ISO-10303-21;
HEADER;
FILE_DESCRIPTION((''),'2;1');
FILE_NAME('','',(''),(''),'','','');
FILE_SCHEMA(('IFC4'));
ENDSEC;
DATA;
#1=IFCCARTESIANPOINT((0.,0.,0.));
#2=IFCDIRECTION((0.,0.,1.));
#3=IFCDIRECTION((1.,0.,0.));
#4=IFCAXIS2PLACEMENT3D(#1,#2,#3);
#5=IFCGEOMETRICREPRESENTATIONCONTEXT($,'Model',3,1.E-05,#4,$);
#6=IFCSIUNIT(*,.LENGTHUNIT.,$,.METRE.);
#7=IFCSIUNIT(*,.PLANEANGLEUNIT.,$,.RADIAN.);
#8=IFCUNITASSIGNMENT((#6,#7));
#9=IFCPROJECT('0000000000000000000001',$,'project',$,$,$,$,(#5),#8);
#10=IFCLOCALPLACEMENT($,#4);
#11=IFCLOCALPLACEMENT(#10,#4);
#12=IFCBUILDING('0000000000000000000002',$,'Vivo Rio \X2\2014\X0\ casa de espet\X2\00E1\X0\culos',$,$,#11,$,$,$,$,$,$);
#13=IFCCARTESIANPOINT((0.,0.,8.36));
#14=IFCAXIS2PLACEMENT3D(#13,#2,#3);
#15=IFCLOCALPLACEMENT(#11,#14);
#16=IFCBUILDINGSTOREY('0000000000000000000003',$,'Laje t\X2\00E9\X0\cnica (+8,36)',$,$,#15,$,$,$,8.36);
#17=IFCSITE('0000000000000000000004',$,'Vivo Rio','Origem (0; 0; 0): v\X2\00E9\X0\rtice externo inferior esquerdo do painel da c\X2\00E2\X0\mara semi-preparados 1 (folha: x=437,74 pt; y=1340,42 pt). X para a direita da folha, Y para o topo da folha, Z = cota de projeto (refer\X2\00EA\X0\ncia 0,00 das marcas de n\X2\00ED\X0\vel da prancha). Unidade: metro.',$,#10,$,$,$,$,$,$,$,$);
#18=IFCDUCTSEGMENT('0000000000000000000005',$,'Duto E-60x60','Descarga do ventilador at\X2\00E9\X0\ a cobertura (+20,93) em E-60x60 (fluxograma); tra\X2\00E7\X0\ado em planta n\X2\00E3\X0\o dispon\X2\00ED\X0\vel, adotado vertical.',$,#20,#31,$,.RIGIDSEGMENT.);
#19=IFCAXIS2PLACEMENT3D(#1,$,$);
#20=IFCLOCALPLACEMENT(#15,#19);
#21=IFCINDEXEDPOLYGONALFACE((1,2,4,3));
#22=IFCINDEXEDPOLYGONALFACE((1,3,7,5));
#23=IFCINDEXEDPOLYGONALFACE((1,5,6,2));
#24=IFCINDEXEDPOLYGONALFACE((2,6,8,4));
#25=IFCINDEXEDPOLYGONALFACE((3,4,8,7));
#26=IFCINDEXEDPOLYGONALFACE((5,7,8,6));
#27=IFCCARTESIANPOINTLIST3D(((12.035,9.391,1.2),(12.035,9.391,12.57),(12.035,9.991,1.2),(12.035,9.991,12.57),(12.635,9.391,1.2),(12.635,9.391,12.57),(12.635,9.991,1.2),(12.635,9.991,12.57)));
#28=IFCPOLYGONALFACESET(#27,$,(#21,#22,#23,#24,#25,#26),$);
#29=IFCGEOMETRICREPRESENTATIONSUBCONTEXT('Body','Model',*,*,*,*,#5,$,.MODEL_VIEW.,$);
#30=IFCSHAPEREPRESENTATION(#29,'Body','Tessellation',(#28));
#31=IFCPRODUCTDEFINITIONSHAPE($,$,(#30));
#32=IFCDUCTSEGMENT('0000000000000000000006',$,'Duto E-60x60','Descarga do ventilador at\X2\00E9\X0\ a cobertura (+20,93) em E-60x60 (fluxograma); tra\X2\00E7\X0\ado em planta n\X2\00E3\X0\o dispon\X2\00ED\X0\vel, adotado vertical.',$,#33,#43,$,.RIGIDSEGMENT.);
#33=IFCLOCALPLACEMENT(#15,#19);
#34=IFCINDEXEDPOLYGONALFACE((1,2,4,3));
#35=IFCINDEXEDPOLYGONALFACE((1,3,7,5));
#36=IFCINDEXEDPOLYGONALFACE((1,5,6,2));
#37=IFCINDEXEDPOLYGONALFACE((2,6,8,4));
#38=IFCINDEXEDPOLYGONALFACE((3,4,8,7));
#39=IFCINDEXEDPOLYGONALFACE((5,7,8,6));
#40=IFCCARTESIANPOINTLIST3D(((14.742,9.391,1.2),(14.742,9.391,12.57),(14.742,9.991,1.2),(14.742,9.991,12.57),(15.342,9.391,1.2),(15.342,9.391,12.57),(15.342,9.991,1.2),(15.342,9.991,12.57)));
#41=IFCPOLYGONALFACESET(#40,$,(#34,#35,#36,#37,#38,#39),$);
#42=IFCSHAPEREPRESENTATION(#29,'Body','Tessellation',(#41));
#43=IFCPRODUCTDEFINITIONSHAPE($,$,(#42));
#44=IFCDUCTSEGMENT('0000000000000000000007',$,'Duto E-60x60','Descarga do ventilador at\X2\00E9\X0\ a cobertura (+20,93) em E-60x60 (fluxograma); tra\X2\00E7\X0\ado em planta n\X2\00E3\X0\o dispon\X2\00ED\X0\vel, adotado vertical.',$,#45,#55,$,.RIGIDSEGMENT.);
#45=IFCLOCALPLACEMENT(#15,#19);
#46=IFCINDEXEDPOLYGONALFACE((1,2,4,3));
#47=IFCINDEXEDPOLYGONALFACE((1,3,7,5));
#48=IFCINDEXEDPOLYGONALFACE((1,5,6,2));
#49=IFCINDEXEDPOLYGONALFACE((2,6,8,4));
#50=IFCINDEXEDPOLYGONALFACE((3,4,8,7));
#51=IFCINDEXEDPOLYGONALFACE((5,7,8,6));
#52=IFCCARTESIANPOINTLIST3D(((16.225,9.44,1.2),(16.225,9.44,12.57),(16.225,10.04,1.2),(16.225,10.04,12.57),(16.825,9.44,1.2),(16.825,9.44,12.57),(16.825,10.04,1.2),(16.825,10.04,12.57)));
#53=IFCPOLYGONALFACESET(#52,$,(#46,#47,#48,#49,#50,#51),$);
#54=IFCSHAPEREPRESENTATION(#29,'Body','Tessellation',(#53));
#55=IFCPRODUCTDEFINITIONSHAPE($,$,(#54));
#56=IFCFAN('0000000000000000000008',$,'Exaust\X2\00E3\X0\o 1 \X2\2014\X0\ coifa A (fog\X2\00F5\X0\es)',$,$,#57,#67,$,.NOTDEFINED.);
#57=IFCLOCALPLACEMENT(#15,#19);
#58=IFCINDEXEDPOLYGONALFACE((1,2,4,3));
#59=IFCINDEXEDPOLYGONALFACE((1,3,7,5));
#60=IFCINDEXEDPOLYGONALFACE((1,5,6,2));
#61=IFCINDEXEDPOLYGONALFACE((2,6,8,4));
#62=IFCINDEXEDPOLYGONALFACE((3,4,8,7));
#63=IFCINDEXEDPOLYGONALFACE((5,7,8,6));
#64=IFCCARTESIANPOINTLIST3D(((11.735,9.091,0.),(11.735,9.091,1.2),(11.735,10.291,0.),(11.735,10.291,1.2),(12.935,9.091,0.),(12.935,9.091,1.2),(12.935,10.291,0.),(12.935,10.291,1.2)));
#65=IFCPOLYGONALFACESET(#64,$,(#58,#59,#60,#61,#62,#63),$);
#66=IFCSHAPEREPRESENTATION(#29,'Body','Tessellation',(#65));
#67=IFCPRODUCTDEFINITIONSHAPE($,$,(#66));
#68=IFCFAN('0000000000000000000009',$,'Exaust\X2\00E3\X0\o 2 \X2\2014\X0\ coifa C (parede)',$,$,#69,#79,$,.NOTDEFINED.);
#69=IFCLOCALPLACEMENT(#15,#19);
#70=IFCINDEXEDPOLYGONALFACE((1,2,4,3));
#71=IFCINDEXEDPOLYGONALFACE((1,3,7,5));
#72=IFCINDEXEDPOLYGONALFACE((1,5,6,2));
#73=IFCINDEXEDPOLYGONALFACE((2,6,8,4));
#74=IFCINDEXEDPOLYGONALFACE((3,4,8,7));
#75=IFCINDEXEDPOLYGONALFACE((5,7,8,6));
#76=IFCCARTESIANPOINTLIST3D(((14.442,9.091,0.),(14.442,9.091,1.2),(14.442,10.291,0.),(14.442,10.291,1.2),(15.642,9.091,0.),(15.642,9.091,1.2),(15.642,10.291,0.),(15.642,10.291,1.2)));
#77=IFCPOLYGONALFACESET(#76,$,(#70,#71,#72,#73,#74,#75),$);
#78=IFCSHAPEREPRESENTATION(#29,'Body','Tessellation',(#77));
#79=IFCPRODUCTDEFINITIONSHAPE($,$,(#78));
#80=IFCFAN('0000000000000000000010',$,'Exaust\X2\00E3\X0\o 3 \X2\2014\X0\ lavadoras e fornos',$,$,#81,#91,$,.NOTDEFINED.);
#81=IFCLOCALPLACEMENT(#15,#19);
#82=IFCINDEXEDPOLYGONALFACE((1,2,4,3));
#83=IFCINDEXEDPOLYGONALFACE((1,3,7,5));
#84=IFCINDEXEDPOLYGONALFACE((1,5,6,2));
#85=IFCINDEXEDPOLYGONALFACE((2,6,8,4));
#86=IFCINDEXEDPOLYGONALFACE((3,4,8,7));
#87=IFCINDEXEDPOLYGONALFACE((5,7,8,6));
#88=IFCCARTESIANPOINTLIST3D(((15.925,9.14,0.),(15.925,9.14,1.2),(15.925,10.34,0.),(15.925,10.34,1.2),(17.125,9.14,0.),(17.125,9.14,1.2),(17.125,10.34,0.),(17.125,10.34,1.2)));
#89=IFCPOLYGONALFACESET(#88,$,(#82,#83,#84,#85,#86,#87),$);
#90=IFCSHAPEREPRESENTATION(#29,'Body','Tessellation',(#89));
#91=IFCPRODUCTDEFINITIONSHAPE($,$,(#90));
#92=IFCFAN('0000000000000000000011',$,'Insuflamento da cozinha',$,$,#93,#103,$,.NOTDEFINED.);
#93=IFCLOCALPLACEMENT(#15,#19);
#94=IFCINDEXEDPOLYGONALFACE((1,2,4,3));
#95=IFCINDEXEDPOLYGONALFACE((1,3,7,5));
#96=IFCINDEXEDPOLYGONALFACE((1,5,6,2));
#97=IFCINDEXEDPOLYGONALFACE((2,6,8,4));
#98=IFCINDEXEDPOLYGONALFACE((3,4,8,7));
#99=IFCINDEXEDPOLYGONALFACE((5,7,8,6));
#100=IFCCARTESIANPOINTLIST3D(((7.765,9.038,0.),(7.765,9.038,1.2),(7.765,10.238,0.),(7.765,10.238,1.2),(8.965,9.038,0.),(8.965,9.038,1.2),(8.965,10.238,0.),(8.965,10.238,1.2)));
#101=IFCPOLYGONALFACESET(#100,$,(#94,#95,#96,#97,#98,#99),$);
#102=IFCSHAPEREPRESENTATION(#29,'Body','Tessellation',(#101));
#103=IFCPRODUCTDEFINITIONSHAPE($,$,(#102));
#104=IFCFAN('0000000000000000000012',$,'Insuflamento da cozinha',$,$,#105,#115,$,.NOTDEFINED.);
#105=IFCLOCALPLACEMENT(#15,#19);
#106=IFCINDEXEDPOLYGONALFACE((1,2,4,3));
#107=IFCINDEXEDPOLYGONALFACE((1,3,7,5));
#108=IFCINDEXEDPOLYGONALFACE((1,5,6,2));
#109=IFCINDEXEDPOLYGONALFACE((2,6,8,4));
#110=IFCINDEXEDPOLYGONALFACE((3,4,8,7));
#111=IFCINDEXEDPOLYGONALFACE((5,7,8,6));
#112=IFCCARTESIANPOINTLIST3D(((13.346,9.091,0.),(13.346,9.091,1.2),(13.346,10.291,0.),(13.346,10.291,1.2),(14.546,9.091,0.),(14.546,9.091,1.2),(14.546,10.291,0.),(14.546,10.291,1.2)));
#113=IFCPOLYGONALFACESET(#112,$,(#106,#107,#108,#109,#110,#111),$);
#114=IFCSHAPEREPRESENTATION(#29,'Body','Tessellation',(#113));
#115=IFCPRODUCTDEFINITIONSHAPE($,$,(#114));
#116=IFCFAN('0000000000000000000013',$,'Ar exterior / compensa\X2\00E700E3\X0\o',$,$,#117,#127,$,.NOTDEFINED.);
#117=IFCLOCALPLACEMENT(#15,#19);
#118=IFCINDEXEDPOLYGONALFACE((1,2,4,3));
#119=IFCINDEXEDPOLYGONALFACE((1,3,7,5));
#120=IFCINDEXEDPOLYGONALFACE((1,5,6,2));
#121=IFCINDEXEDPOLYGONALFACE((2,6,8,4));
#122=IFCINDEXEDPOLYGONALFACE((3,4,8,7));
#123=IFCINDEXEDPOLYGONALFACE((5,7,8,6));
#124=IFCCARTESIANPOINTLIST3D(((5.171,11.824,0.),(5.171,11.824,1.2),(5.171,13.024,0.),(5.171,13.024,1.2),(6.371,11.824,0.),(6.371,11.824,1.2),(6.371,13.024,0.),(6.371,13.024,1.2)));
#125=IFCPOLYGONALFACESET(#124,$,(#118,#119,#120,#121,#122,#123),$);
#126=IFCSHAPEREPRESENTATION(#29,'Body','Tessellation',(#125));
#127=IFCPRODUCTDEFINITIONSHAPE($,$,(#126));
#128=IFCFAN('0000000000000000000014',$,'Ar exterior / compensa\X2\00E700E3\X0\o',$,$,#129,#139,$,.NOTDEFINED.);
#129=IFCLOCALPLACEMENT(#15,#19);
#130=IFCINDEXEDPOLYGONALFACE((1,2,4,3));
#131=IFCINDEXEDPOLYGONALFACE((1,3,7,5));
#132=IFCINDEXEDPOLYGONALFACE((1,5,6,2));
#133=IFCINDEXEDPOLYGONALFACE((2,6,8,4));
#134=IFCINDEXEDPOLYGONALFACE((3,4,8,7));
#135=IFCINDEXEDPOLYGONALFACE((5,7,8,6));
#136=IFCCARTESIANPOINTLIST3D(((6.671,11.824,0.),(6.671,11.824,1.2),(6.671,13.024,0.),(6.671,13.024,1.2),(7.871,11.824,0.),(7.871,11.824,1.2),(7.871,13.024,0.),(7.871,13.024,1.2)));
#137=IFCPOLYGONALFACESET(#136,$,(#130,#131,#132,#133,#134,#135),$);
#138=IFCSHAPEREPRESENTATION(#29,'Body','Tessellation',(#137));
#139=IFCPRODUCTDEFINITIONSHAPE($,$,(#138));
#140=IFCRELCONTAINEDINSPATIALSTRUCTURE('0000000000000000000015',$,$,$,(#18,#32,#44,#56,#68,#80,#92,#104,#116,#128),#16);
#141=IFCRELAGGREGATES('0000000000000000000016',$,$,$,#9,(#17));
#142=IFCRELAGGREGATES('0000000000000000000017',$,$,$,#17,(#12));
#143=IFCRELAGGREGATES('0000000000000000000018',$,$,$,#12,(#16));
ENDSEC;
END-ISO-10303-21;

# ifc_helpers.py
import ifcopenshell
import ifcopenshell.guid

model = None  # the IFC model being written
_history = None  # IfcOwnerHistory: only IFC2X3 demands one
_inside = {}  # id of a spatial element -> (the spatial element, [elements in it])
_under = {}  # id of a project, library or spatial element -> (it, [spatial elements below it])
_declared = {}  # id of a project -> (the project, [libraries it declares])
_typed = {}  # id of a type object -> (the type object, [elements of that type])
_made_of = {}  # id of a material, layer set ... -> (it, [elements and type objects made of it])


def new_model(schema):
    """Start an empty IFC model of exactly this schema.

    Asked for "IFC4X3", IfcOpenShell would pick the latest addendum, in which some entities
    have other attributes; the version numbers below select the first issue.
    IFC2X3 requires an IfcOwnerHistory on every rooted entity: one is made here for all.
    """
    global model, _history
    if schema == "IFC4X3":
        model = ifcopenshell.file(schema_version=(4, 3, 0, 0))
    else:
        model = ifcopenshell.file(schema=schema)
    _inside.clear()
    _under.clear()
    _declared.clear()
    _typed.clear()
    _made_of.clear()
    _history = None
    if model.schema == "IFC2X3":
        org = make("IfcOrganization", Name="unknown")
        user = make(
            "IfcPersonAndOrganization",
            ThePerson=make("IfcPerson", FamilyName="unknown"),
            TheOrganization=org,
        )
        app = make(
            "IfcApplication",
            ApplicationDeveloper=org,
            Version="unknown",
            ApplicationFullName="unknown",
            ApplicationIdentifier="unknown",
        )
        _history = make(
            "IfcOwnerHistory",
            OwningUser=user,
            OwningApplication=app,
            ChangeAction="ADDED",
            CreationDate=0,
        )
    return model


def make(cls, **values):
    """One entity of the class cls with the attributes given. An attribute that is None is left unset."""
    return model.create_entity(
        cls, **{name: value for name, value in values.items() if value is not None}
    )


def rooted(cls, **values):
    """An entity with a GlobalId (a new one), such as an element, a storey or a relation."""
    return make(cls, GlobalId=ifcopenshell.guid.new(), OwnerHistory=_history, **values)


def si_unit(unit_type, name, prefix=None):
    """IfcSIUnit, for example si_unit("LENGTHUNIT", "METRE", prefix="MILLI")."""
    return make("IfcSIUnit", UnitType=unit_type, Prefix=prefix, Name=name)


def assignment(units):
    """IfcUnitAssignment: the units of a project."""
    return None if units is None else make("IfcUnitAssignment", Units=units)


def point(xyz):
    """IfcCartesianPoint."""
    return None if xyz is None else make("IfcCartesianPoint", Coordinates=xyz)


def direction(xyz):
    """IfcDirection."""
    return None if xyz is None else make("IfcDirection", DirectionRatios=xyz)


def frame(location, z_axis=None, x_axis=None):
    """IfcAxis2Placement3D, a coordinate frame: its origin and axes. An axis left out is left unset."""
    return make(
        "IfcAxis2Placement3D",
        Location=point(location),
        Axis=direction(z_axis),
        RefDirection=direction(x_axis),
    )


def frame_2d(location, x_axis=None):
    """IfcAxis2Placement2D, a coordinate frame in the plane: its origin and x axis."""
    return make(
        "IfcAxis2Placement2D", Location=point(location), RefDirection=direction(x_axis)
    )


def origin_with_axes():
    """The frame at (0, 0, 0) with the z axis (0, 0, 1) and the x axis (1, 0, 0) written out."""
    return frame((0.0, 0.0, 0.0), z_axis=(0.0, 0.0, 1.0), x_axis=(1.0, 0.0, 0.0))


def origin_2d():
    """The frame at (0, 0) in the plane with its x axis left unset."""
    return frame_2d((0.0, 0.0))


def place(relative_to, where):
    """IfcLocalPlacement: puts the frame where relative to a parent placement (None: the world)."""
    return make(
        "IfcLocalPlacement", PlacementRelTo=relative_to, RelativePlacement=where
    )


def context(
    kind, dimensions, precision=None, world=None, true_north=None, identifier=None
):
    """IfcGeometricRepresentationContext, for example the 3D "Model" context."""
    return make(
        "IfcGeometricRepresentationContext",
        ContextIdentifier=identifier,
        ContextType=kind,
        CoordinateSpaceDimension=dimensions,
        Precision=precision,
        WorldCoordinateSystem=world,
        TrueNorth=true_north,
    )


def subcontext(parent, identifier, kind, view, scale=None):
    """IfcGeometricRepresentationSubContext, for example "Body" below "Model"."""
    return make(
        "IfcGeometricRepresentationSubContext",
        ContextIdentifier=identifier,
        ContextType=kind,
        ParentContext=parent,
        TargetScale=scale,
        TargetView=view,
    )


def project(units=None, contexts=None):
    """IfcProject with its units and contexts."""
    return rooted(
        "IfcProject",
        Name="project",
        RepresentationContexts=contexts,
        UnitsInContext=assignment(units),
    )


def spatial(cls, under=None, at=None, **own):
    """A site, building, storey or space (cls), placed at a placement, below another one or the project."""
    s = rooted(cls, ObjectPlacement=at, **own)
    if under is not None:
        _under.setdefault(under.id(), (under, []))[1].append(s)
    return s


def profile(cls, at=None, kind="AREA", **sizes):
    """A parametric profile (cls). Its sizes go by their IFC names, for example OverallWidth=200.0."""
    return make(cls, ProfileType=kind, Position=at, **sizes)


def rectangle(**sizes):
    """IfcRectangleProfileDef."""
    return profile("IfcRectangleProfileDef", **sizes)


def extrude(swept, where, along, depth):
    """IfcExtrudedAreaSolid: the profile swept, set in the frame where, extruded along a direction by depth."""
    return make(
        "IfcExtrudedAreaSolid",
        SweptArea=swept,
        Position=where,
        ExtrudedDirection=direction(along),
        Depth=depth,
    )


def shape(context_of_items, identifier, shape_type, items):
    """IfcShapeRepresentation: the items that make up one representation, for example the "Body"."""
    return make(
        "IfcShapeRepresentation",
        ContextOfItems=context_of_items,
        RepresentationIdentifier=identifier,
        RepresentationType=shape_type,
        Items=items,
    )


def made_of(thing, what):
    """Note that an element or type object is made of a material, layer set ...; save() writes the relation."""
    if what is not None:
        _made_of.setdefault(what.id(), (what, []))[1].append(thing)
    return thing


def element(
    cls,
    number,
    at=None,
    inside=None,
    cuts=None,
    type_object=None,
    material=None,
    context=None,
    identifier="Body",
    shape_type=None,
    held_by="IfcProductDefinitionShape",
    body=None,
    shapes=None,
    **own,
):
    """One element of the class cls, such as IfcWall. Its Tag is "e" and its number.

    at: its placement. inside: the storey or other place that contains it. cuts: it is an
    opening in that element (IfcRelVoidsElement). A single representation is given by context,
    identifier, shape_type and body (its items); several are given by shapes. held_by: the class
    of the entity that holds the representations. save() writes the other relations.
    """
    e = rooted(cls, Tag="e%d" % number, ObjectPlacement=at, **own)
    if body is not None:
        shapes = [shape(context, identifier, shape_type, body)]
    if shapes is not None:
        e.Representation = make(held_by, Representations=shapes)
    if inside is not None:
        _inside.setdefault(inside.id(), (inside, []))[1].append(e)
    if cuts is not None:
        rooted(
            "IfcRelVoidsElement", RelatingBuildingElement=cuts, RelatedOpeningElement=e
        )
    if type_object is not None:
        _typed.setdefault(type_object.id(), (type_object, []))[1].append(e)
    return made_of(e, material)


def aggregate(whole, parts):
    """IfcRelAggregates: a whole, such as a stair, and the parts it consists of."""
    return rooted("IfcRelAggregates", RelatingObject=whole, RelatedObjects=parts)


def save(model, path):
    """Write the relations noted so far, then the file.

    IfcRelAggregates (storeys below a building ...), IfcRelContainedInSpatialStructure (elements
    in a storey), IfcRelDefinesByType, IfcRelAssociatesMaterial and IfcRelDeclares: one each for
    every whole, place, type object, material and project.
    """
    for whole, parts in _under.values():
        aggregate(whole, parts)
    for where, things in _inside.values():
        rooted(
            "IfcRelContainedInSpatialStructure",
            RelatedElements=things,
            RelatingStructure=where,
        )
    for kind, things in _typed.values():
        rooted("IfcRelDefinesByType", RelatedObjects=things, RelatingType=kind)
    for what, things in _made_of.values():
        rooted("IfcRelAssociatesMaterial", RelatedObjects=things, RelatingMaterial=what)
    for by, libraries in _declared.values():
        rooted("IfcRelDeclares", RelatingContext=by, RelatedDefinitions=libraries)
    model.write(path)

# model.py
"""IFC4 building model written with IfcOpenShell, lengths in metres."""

from ifc_helpers import new_model, si_unit, frame, origin_with_axes, origin_2d, place, context, subcontext, project, spatial, rectangle, extrude, element, save


model = new_model("IFC4")

# Units and contexts
model_context = context("Model", 3, precision=1e-05, world=origin_with_axes())
body_context = subcontext(model_context, "Body", "Model", "MODEL_VIEW")
ifc_project = project(units=[si_unit("LENGTHUNIT", "METRE"), si_unit("PLANEANGLEUNIT", "RADIAN")], contexts=[model_context])

# Site, building, storey
site_placement = place(None, origin_with_axes())
site = spatial("IfcSite", under=ifc_project, at=site_placement, Name="Vivo Rio", Description="Origem (0; 0; 0): vértice externo inferior esquerdo do painel da câmara semi-preparados 1 (folha: x=437,74 pt; y=1340,42 pt). X para a direita da folha, Y para o topo da folha, Z = cota de projeto (referência 0,00 das marcas de nível da prancha). Unidade: metro.")
building_placement = place(site_placement, origin_with_axes())
building = spatial("IfcBuilding", under=site, at=building_placement, Name="Vivo Rio — casa de espetáculos")
storey_placement = place(building_placement, frame((0.0, 0.0, 8.36), z_axis=(0.0, 0.0, 1.0), x_axis=(1.0, 0.0, 0.0)))
storey = spatial("IfcBuildingStorey", under=building, at=storey_placement, Name="Laje técnica (+8,36)", Elevation=8.36)

# Duct segments
duct_segment_1_placement = place(storey_placement, origin_with_axes())
element("IfcDuctSegment", 1, at=duct_segment_1_placement, inside=storey, Name="Duto E-60x60", Description="Descarga do ventilador até a cobertura (+20,93) em E-60x60 (fluxograma); traçado em planta não disponível, adotado vertical.", PredefinedType="RIGIDSEGMENT", context=body_context, shape_type="SweptSolid", body=[
    extrude(rectangle(XDim=0.6, YDim=0.6, at=origin_2d()), frame((12.335, 9.691, 1.2), z_axis=(0.0, 0.0, 1.0), x_axis=(1.0, 0.0, 0.0)), (0.0, 0.0, 1.0), 11.37),
])
duct_segment_2_placement = place(storey_placement, origin_with_axes())
element("IfcDuctSegment", 2, at=duct_segment_2_placement, inside=storey, Name="Duto E-60x60", Description="Descarga do ventilador até a cobertura (+20,93) em E-60x60 (fluxograma); traçado em planta não disponível, adotado vertical.", PredefinedType="RIGIDSEGMENT", context=body_context, shape_type="SweptSolid", body=[
    extrude(rectangle(XDim=0.6, YDim=0.6, at=origin_2d()), frame((15.042, 9.691, 1.2), z_axis=(0.0, 0.0, 1.0), x_axis=(1.0, 0.0, 0.0)), (0.0, 0.0, 1.0), 11.37),
])
duct_segment_3_placement = place(storey_placement, origin_with_axes())
element("IfcDuctSegment", 3, at=duct_segment_3_placement, inside=storey, Name="Duto E-60x60", Description="Descarga do ventilador até a cobertura (+20,93) em E-60x60 (fluxograma); traçado em planta não disponível, adotado vertical.", PredefinedType="RIGIDSEGMENT", context=body_context, shape_type="SweptSolid", body=[
    extrude(rectangle(XDim=0.6, YDim=0.6, at=origin_2d()), frame((16.525, 9.74, 1.2), z_axis=(0.0, 0.0, 1.0), x_axis=(1.0, 0.0, 0.0)), (0.0, 0.0, 1.0), 11.37),
])

# Fans
fan_1_placement = place(storey_placement, origin_with_axes())
element("IfcFan", 4, at=fan_1_placement, inside=storey, Name="Exaustão 1 — coifa A (fogões)", PredefinedType="NOTDEFINED", context=body_context, shape_type="SweptSolid", body=[
    extrude(rectangle(XDim=1.2, YDim=1.2, at=origin_2d()), frame((12.335, 9.691, 0.0), z_axis=(0.0, 0.0, 1.0), x_axis=(1.0, 0.0, 0.0)), (0.0, 0.0, 1.0), 1.2),
])
fan_2_placement = place(storey_placement, origin_with_axes())
element("IfcFan", 5, at=fan_2_placement, inside=storey, Name="Exaustão 2 — coifa C (parede)", PredefinedType="NOTDEFINED", context=body_context, shape_type="SweptSolid", body=[
    extrude(rectangle(XDim=1.2, YDim=1.2, at=origin_2d()), frame((15.042, 9.691, 0.0), z_axis=(0.0, 0.0, 1.0), x_axis=(1.0, 0.0, 0.0)), (0.0, 0.0, 1.0), 1.2),
])
fan_3_placement = place(storey_placement, origin_with_axes())
element("IfcFan", 6, at=fan_3_placement, inside=storey, Name="Exaustão 3 — lavadoras e fornos", PredefinedType="NOTDEFINED", context=body_context, shape_type="SweptSolid", body=[
    extrude(rectangle(XDim=1.2, YDim=1.2, at=origin_2d()), frame((16.525, 9.74, 0.0), z_axis=(0.0, 0.0, 1.0), x_axis=(1.0, 0.0, 0.0)), (0.0, 0.0, 1.0), 1.2),
])
fan_4_placement = place(storey_placement, origin_with_axes())
element("IfcFan", 7, at=fan_4_placement, inside=storey, Name="Insuflamento da cozinha", PredefinedType="NOTDEFINED", context=body_context, shape_type="SweptSolid", body=[
    extrude(rectangle(XDim=1.2, YDim=1.2, at=origin_2d()), frame((8.365, 9.638, 0.0), z_axis=(0.0, 0.0, 1.0), x_axis=(1.0, 0.0, 0.0)), (0.0, 0.0, 1.0), 1.2),
])
fan_5_placement = place(storey_placement, origin_with_axes())
element("IfcFan", 8, at=fan_5_placement, inside=storey, Name="Insuflamento da cozinha", PredefinedType="NOTDEFINED", context=body_context, shape_type="SweptSolid", body=[
    extrude(rectangle(XDim=1.2, YDim=1.2, at=origin_2d()), frame((13.946, 9.691, 0.0), z_axis=(0.0, 0.0, 1.0), x_axis=(1.0, 0.0, 0.0)), (0.0, 0.0, 1.0), 1.2),
])
fan_6_placement = place(storey_placement, origin_with_axes())
element("IfcFan", 9, at=fan_6_placement, inside=storey, Name="Ar exterior / compensação", PredefinedType="NOTDEFINED", context=body_context, shape_type="SweptSolid", body=[
    extrude(rectangle(XDim=1.2, YDim=1.2, at=origin_2d()), frame((5.771, 12.424, 0.0), z_axis=(0.0, 0.0, 1.0), x_axis=(1.0, 0.0, 0.0)), (0.0, 0.0, 1.0), 1.2),
])
fan_7_placement = place(storey_placement, origin_with_axes())
element("IfcFan", 10, at=fan_7_placement, inside=storey, Name="Ar exterior / compensação", PredefinedType="NOTDEFINED", context=body_context, shape_type="SweptSolid", body=[
    extrude(rectangle(XDim=1.2, YDim=1.2, at=origin_2d()), frame((7.271, 12.424, 0.0), z_axis=(0.0, 0.0, 1.0), x_axis=(1.0, 0.0, 0.0)), (0.0, 0.0, 1.0), 1.2),
])

save(model, "model.ifc")
